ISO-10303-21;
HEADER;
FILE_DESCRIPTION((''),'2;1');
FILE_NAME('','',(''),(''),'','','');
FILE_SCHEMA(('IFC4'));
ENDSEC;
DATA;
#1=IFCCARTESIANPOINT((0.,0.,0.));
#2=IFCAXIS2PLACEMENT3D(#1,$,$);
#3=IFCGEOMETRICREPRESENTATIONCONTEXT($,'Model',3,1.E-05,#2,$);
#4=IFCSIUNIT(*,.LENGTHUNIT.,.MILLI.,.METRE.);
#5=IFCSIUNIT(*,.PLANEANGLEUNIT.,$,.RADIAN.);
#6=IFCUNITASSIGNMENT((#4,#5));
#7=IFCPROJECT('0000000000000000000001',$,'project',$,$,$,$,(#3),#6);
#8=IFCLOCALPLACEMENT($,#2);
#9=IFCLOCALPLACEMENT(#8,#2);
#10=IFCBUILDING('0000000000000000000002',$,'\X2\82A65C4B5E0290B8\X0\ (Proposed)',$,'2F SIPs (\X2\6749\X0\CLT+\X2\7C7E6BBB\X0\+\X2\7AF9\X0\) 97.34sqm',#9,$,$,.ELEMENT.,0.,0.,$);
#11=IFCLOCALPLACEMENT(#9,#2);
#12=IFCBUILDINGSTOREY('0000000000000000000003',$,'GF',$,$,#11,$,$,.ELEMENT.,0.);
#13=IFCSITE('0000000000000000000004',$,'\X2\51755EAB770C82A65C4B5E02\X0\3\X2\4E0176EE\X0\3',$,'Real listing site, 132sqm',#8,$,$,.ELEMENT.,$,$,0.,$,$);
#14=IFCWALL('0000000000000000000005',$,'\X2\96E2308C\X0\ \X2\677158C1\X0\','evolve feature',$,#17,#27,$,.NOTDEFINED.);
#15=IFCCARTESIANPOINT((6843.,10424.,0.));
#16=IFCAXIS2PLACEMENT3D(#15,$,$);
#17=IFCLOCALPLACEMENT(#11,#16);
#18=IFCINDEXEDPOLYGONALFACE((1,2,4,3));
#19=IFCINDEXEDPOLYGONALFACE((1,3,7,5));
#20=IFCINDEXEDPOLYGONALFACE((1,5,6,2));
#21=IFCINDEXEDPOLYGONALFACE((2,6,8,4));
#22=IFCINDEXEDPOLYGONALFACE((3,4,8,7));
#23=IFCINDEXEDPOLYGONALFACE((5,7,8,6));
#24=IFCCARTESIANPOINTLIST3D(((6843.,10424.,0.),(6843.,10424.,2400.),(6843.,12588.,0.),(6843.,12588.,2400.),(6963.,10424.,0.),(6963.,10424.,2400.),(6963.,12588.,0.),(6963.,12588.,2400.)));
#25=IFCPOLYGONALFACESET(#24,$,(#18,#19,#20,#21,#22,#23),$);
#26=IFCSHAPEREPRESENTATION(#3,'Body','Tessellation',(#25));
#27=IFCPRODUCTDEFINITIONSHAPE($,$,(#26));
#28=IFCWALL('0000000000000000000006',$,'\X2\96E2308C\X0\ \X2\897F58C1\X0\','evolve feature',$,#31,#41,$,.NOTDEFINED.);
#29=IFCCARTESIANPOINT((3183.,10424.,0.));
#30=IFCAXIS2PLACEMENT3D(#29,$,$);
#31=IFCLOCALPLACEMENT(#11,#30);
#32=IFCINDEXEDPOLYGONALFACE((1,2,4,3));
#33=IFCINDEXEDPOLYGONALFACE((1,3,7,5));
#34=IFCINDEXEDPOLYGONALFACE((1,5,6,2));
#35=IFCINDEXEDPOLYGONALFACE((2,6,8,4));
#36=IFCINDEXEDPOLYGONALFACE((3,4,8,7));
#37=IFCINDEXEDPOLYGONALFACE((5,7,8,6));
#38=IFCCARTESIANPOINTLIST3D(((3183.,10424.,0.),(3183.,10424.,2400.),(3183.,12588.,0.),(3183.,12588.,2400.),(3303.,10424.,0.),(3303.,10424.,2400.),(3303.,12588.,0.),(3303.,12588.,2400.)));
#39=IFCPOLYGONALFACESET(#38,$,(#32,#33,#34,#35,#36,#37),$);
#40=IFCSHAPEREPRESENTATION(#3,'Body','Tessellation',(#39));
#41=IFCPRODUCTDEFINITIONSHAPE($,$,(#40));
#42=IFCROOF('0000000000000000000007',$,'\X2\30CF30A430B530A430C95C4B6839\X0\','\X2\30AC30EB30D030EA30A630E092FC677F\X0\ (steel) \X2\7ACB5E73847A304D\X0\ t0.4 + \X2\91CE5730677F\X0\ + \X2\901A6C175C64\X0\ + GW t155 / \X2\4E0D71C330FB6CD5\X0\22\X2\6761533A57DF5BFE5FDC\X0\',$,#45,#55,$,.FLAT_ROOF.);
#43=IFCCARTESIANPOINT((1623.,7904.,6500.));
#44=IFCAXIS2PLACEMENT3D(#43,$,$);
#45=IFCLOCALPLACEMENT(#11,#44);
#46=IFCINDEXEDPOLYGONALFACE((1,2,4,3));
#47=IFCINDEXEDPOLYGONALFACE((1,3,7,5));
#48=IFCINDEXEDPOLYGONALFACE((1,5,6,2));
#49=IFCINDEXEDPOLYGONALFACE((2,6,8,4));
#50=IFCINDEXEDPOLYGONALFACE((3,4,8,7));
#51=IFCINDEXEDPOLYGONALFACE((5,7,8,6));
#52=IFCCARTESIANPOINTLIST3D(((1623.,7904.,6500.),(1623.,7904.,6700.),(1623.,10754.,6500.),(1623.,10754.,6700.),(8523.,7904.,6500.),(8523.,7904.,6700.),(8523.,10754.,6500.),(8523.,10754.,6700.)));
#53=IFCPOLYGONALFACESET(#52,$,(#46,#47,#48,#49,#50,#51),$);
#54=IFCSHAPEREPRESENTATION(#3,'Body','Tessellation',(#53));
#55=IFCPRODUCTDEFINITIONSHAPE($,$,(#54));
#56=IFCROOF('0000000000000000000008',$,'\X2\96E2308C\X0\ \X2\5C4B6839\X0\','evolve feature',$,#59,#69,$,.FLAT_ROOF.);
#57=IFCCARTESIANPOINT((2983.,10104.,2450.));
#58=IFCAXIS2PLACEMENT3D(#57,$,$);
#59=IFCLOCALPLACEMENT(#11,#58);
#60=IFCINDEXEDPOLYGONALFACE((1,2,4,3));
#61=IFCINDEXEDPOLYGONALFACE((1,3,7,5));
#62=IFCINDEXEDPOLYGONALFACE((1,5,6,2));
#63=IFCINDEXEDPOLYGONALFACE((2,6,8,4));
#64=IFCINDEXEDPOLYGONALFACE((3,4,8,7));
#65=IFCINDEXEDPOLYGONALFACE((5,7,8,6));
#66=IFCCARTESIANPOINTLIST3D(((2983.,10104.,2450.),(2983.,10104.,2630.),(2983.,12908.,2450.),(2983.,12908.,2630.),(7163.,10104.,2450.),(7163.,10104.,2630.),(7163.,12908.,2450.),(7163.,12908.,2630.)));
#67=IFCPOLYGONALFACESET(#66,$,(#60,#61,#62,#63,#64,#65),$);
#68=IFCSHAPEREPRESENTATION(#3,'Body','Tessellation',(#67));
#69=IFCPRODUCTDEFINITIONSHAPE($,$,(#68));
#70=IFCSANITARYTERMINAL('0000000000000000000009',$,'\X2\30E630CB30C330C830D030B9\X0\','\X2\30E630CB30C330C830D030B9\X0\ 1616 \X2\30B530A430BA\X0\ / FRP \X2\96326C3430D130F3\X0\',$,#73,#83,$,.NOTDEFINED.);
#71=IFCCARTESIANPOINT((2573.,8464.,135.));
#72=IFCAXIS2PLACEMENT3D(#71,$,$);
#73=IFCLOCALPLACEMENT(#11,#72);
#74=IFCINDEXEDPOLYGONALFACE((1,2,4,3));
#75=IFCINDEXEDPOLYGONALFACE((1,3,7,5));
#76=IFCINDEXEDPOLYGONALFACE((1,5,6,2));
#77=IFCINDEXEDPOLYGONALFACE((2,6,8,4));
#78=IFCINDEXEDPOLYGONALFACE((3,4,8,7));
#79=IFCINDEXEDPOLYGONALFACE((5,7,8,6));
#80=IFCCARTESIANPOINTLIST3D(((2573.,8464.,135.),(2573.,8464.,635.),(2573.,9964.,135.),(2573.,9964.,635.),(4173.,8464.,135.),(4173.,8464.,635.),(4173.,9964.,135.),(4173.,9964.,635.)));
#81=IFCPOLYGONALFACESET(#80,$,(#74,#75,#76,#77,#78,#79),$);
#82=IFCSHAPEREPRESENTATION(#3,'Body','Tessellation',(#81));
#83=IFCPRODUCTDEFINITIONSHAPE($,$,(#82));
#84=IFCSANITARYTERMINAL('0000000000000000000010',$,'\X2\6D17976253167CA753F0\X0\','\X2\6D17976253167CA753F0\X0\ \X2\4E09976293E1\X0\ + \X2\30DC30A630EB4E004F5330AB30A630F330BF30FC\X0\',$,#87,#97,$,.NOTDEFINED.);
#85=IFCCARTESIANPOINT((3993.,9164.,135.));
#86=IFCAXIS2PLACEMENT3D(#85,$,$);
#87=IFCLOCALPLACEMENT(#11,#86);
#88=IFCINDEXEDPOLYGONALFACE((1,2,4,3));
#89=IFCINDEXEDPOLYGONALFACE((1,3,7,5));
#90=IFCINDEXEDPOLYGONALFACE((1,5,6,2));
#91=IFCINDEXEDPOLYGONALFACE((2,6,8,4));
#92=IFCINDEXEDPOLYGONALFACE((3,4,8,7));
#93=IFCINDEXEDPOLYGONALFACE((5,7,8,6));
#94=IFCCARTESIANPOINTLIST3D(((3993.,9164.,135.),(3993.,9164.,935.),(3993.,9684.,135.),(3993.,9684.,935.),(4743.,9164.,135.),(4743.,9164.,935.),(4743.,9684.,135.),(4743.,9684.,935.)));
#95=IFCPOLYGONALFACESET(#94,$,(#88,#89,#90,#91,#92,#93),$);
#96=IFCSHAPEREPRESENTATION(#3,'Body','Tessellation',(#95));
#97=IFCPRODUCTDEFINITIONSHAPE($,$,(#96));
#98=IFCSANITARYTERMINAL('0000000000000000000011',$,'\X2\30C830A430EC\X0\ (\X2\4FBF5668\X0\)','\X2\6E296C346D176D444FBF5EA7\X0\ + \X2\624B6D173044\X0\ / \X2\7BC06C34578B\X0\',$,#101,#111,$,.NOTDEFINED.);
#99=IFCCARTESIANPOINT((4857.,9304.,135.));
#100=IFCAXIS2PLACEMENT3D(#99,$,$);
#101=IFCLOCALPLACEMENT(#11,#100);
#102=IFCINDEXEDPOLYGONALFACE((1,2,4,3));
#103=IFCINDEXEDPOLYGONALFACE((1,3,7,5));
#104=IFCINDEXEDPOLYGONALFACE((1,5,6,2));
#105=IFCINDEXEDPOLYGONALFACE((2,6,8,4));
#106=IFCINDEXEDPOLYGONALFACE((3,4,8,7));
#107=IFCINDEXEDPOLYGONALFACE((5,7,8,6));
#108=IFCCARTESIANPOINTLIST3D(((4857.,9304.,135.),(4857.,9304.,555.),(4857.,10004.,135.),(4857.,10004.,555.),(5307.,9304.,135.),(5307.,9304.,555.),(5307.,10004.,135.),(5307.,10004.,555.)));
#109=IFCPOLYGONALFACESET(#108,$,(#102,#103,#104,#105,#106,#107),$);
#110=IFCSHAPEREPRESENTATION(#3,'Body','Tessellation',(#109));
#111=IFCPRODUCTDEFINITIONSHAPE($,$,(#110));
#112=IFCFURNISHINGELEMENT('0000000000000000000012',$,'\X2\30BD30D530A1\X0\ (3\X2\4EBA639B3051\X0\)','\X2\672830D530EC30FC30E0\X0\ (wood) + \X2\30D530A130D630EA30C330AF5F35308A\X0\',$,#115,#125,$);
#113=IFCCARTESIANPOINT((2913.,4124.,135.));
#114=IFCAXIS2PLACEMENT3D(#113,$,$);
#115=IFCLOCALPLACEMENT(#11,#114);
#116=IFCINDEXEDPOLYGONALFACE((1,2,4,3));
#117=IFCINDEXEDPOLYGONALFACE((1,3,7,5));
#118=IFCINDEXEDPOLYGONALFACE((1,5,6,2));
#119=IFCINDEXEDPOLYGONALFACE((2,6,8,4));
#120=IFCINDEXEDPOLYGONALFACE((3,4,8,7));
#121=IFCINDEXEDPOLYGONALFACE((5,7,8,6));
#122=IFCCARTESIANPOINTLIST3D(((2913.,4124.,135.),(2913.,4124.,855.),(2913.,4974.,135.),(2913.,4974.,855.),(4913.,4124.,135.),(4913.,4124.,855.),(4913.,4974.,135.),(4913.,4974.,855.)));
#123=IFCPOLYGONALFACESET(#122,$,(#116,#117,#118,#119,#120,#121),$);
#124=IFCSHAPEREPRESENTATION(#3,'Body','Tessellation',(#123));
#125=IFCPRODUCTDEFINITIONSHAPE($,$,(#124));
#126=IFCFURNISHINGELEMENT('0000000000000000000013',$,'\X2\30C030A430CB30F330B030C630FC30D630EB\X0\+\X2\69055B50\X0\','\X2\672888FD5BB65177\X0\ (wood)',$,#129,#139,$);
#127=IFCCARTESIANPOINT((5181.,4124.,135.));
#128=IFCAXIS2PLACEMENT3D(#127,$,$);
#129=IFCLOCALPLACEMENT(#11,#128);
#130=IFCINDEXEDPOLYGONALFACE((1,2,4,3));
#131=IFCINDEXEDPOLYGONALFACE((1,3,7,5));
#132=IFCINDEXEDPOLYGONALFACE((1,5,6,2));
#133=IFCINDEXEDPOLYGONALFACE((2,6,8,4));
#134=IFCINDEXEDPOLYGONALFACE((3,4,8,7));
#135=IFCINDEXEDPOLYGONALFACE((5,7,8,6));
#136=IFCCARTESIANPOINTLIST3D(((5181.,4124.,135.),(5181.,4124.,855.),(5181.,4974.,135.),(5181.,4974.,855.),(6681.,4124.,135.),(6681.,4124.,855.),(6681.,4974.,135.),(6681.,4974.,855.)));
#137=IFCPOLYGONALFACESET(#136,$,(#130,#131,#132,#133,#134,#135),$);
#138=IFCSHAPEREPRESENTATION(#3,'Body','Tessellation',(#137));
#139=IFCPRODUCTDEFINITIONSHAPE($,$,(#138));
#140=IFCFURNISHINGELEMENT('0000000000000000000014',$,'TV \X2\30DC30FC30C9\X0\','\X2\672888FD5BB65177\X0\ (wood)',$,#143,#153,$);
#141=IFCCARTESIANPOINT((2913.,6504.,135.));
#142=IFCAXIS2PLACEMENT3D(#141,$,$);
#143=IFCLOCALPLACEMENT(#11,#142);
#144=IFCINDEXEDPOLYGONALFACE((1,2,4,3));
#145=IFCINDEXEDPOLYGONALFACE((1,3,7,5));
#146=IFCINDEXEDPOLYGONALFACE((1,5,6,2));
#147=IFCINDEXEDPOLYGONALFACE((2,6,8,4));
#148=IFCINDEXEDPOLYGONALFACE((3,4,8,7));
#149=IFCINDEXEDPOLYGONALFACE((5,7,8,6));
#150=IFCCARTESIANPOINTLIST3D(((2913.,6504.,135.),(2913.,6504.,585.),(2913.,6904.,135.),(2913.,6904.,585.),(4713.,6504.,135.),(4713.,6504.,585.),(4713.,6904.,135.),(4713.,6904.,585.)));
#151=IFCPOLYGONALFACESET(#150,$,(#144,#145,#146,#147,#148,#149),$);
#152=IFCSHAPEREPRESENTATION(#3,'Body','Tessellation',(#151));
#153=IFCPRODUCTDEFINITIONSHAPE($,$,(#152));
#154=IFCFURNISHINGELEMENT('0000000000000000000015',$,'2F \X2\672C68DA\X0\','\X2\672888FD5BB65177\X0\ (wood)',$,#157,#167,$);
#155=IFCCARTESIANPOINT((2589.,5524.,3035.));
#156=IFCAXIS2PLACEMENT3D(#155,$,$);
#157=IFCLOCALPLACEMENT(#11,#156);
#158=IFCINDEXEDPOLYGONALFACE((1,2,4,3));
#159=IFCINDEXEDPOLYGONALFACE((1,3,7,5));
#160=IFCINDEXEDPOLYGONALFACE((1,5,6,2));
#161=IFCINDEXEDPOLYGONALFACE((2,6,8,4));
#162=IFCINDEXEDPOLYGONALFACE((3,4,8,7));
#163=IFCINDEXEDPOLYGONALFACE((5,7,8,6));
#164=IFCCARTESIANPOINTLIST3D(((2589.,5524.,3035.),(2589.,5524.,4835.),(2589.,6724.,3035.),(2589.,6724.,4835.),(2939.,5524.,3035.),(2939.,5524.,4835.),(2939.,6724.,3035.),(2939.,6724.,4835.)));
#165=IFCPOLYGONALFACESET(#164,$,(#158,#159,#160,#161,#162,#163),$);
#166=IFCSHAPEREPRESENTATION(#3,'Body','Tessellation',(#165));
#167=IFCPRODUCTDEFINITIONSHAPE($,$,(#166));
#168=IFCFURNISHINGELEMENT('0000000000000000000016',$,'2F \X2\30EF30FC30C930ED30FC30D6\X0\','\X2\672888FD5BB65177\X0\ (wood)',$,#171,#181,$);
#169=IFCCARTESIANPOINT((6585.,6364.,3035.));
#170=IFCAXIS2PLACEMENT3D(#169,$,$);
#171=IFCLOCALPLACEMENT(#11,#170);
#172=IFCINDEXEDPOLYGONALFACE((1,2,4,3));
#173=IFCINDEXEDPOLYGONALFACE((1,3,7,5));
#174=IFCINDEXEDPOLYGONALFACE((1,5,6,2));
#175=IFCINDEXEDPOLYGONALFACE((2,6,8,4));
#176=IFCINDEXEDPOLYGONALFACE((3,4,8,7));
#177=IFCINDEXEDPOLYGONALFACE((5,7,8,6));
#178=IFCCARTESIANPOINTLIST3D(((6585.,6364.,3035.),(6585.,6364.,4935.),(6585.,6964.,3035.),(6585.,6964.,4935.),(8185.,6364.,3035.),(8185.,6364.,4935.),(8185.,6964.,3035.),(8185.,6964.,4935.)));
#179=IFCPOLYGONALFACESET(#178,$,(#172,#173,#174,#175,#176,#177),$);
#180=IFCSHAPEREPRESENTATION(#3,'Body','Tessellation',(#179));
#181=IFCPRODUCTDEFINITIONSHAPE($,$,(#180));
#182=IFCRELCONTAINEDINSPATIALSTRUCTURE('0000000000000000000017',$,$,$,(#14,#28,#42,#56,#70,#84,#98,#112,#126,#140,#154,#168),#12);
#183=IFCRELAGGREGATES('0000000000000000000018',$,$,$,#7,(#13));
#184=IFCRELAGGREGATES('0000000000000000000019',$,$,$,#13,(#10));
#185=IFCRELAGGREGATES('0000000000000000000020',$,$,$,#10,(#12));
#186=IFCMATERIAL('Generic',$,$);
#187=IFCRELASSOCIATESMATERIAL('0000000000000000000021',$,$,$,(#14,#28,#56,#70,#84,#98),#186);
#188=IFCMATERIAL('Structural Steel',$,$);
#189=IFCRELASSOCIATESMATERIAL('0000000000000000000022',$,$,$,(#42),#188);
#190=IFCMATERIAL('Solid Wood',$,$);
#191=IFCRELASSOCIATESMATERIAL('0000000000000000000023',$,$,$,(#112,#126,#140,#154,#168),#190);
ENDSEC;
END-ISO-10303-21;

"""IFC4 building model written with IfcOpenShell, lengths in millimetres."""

from ifc_helpers import new_model, si_unit, frame, frame_2d, origin, place, context, project, spatial, rectangle, extrude, material, element, save


model = new_model("IFC4")

# Units and contexts
model_context = context("Model", 3, precision=1e-05, world=origin())
ifc_project = project(units=[si_unit("LENGTHUNIT", "METRE", prefix="MILLI"), si_unit("PLANEANGLEUNIT", "RADIAN")], contexts=[model_context])

# Site, building, storey
site_placement = place(None, origin())
site = spatial("IfcSite", under=ifc_project, at=site_placement, Name="兵庫県芦屋市3丁目3", ObjectType="Real listing site, 132sqm", CompositionType="ELEMENT", RefElevation=0.0)
building_placement = place(site_placement, origin())
building = spatial("IfcBuilding", under=site, at=building_placement, Name="芦屋市邸 (Proposed)", ObjectType="2F SIPs (杉CLT+籾殻+竹) 97.34sqm", CompositionType="ELEMENT", ElevationOfRefHeight=0.0, ElevationOfTerrain=0.0)
storey_placement = place(building_placement, origin())
storey = spatial("IfcBuildingStorey", under=building, at=storey_placement, Name="GF", CompositionType="ELEMENT", Elevation=0.0)

# Shared definitions
ifc_material_1 = material(Name="Generic")

# Shared definitions
ifc_material_2 = material(Name="Solid Wood")

# Walls
wall_1_placement = place(storey_placement, frame((6843.0, 10424.0, 0.0)))
element("IfcWall", 1, at=wall_1_placement, inside=storey, material=ifc_material_1, Name="離れ 東壁", Description="evolve feature", PredefinedType="NOTDEFINED", context=model_context, shape_type="SweptSolid", body=[
    extrude(rectangle(XDim=120.0, YDim=2164.0, at=frame_2d((60.0, 1082.0))), frame((6843.0, 10424.0, 0.0)), (0.0, 0.0, 1.0), 2400.0),
])
wall_2_placement = place(storey_placement, frame((3183.0, 10424.0, 0.0)))
element("IfcWall", 2, at=wall_2_placement, inside=storey, material=ifc_material_1, Name="離れ 西壁", Description="evolve feature", PredefinedType="NOTDEFINED", context=model_context, shape_type="SweptSolid", body=[
    extrude(rectangle(XDim=120.0, YDim=2164.0, at=frame_2d((60.0, 1082.0))), frame((3183.0, 10424.0, 0.0)), (0.0, 0.0, 1.0), 2400.0),
])

# Roofs
ifc_material_3 = material(Name="Structural Steel")
roof_1_placement = place(storey_placement, frame((1623.0, 7904.0, 6500.0)))
element("IfcRoof", 3, at=roof_1_placement, inside=storey, material=ifc_material_3, Name="ハイサイド屋根", Description="ガルバリウム鋼板 (steel) 立平葺き t0.4 + 野地板 + 通気層 + GW t155 / 不燃・法22条区域対応", PredefinedType="FLAT_ROOF", context=model_context, shape_type="SweptSolid", body=[
    extrude(rectangle(XDim=6900.0, YDim=2850.0, at=frame_2d((3450.0, 1425.0))), frame((1623.0, 7904.0, 6500.0)), (0.0, 0.0, 1.0), 200.0),
])
roof_2_placement = place(storey_placement, frame((2983.0, 10104.0, 2450.0)))
element("IfcRoof", 4, at=roof_2_placement, inside=storey, material=ifc_material_1, Name="離れ 屋根", Description="evolve feature", PredefinedType="FLAT_ROOF", context=model_context, shape_type="SweptSolid", body=[
    extrude(rectangle(XDim=4180.0, YDim=2804.0, at=frame_2d((2090.0, 1402.0))), frame((2983.0, 10104.0, 2450.0)), (0.0, 0.0, 1.0), 180.0),
])

# Sanitary terminals
sanitary_terminal_1_placement = place(storey_placement, frame((2573.0, 8464.0, 135.0)))
element("IfcSanitaryTerminal", 5, at=sanitary_terminal_1_placement, inside=storey, material=ifc_material_1, Name="ユニットバス", Description="ユニットバス 1616 サイズ / FRP 防水パン", PredefinedType="NOTDEFINED", context=model_context, shape_type="SweptSolid", body=[
    extrude(rectangle(XDim=1600.0, YDim=1500.0, at=frame_2d((800.0, 750.0))), frame((2573.0, 8464.0, 135.0)), (0.0, 0.0, 1.0), 500.0),
])
sanitary_terminal_2_placement = place(storey_placement, frame((3993.0, 9164.0, 135.0)))
element("IfcSanitaryTerminal", 6, at=sanitary_terminal_2_placement, inside=storey, material=ifc_material_1, Name="洗面化粧台", Description="洗面化粧台 三面鏡 + ボウル一体カウンター", PredefinedType="NOTDEFINED", context=model_context, shape_type="SweptSolid", body=[
    extrude(rectangle(XDim=750.0, YDim=520.0, at=frame_2d((375.0, 260.0))), frame((3993.0, 9164.0, 135.0)), (0.0, 0.0, 1.0), 800.0),
])
sanitary_terminal_3_placement = place(storey_placement, frame((4857.0, 9304.0, 135.0)))
element("IfcSanitaryTerminal", 7, at=sanitary_terminal_3_placement, inside=storey, material=ifc_material_1, Name="トイレ (便器)", Description="温水洗浄便座 + 手洗い / 節水型", PredefinedType="NOTDEFINED", context=model_context, shape_type="SweptSolid", body=[
    extrude(rectangle(XDim=450.0, YDim=700.0, at=frame_2d((225.0, 350.0))), frame((4857.0, 9304.0, 135.0)), (0.0, 0.0, 1.0), 420.0),
])

# Furnishing elements
furnishing_1_placement = place(storey_placement, frame((2913.0, 4124.0, 135.0)))
element("IfcFurnishingElement", 8, at=furnishing_1_placement, inside=storey, material=ifc_material_2, Name="ソファ (3人掛け)", Description="木フレーム (wood) + ファブリック張り", context=model_context, shape_type="SweptSolid", body=[
    extrude(rectangle(XDim=2000.0, YDim=850.0, at=frame_2d((1000.0, 425.0))), frame((2913.0, 4124.0, 135.0)), (0.0, 0.0, 1.0), 720.0),
])
furnishing_2_placement = place(storey_placement, frame((5181.0, 4124.0, 135.0)))
element("IfcFurnishingElement", 9, at=furnishing_2_placement, inside=storey, material=ifc_material_2, Name="ダイニングテーブル+椅子", Description="木製家具 (wood)", context=model_context, shape_type="SweptSolid", body=[
    extrude(rectangle(XDim=1500.0, YDim=850.0, at=frame_2d((750.0, 425.0))), frame((5181.0, 4124.0, 135.0)), (0.0, 0.0, 1.0), 720.0),
])
furnishing_3_placement = place(storey_placement, frame((2913.0, 6504.0, 135.0)))
element("IfcFurnishingElement", 10, at=furnishing_3_placement, inside=storey, material=ifc_material_2, Name="TV ボード", Description="木製家具 (wood)", context=model_context, shape_type="SweptSolid", body=[
    extrude(rectangle(XDim=1800.0, YDim=400.0, at=frame_2d((900.0, 200.0))), frame((2913.0, 6504.0, 135.0)), (0.0, 0.0, 1.0), 450.0),
])
furnishing_4_placement = place(storey_placement, frame((2589.0, 5524.0, 3035.0)))
element("IfcFurnishingElement", 11, at=furnishing_4_placement, inside=storey, material=ifc_material_2, Name="2F 本棚", Description="木製家具 (wood)", context=model_context, shape_type="SweptSolid", body=[
    extrude(rectangle(XDim=350.0, YDim=1200.0, at=frame_2d((175.0, 600.0))), frame((2589.0, 5524.0, 3035.0)), (0.0, 0.0, 1.0), 1800.0),
])
furnishing_5_placement = place(storey_placement, frame((6585.0, 6364.0, 3035.0)))
element("IfcFurnishingElement", 12, at=furnishing_5_placement, inside=storey, material=ifc_material_2, Name="2F ワードローブ", Description="木製家具 (wood)", context=model_context, shape_type="SweptSolid", body=[
    extrude(rectangle(XDim=1600.0, YDim=600.0, at=frame_2d((800.0, 300.0))), frame((6585.0, 6364.0, 3035.0)), (0.0, 0.0, 1.0), 1900.0),
])

save(model, "model.ifc")
